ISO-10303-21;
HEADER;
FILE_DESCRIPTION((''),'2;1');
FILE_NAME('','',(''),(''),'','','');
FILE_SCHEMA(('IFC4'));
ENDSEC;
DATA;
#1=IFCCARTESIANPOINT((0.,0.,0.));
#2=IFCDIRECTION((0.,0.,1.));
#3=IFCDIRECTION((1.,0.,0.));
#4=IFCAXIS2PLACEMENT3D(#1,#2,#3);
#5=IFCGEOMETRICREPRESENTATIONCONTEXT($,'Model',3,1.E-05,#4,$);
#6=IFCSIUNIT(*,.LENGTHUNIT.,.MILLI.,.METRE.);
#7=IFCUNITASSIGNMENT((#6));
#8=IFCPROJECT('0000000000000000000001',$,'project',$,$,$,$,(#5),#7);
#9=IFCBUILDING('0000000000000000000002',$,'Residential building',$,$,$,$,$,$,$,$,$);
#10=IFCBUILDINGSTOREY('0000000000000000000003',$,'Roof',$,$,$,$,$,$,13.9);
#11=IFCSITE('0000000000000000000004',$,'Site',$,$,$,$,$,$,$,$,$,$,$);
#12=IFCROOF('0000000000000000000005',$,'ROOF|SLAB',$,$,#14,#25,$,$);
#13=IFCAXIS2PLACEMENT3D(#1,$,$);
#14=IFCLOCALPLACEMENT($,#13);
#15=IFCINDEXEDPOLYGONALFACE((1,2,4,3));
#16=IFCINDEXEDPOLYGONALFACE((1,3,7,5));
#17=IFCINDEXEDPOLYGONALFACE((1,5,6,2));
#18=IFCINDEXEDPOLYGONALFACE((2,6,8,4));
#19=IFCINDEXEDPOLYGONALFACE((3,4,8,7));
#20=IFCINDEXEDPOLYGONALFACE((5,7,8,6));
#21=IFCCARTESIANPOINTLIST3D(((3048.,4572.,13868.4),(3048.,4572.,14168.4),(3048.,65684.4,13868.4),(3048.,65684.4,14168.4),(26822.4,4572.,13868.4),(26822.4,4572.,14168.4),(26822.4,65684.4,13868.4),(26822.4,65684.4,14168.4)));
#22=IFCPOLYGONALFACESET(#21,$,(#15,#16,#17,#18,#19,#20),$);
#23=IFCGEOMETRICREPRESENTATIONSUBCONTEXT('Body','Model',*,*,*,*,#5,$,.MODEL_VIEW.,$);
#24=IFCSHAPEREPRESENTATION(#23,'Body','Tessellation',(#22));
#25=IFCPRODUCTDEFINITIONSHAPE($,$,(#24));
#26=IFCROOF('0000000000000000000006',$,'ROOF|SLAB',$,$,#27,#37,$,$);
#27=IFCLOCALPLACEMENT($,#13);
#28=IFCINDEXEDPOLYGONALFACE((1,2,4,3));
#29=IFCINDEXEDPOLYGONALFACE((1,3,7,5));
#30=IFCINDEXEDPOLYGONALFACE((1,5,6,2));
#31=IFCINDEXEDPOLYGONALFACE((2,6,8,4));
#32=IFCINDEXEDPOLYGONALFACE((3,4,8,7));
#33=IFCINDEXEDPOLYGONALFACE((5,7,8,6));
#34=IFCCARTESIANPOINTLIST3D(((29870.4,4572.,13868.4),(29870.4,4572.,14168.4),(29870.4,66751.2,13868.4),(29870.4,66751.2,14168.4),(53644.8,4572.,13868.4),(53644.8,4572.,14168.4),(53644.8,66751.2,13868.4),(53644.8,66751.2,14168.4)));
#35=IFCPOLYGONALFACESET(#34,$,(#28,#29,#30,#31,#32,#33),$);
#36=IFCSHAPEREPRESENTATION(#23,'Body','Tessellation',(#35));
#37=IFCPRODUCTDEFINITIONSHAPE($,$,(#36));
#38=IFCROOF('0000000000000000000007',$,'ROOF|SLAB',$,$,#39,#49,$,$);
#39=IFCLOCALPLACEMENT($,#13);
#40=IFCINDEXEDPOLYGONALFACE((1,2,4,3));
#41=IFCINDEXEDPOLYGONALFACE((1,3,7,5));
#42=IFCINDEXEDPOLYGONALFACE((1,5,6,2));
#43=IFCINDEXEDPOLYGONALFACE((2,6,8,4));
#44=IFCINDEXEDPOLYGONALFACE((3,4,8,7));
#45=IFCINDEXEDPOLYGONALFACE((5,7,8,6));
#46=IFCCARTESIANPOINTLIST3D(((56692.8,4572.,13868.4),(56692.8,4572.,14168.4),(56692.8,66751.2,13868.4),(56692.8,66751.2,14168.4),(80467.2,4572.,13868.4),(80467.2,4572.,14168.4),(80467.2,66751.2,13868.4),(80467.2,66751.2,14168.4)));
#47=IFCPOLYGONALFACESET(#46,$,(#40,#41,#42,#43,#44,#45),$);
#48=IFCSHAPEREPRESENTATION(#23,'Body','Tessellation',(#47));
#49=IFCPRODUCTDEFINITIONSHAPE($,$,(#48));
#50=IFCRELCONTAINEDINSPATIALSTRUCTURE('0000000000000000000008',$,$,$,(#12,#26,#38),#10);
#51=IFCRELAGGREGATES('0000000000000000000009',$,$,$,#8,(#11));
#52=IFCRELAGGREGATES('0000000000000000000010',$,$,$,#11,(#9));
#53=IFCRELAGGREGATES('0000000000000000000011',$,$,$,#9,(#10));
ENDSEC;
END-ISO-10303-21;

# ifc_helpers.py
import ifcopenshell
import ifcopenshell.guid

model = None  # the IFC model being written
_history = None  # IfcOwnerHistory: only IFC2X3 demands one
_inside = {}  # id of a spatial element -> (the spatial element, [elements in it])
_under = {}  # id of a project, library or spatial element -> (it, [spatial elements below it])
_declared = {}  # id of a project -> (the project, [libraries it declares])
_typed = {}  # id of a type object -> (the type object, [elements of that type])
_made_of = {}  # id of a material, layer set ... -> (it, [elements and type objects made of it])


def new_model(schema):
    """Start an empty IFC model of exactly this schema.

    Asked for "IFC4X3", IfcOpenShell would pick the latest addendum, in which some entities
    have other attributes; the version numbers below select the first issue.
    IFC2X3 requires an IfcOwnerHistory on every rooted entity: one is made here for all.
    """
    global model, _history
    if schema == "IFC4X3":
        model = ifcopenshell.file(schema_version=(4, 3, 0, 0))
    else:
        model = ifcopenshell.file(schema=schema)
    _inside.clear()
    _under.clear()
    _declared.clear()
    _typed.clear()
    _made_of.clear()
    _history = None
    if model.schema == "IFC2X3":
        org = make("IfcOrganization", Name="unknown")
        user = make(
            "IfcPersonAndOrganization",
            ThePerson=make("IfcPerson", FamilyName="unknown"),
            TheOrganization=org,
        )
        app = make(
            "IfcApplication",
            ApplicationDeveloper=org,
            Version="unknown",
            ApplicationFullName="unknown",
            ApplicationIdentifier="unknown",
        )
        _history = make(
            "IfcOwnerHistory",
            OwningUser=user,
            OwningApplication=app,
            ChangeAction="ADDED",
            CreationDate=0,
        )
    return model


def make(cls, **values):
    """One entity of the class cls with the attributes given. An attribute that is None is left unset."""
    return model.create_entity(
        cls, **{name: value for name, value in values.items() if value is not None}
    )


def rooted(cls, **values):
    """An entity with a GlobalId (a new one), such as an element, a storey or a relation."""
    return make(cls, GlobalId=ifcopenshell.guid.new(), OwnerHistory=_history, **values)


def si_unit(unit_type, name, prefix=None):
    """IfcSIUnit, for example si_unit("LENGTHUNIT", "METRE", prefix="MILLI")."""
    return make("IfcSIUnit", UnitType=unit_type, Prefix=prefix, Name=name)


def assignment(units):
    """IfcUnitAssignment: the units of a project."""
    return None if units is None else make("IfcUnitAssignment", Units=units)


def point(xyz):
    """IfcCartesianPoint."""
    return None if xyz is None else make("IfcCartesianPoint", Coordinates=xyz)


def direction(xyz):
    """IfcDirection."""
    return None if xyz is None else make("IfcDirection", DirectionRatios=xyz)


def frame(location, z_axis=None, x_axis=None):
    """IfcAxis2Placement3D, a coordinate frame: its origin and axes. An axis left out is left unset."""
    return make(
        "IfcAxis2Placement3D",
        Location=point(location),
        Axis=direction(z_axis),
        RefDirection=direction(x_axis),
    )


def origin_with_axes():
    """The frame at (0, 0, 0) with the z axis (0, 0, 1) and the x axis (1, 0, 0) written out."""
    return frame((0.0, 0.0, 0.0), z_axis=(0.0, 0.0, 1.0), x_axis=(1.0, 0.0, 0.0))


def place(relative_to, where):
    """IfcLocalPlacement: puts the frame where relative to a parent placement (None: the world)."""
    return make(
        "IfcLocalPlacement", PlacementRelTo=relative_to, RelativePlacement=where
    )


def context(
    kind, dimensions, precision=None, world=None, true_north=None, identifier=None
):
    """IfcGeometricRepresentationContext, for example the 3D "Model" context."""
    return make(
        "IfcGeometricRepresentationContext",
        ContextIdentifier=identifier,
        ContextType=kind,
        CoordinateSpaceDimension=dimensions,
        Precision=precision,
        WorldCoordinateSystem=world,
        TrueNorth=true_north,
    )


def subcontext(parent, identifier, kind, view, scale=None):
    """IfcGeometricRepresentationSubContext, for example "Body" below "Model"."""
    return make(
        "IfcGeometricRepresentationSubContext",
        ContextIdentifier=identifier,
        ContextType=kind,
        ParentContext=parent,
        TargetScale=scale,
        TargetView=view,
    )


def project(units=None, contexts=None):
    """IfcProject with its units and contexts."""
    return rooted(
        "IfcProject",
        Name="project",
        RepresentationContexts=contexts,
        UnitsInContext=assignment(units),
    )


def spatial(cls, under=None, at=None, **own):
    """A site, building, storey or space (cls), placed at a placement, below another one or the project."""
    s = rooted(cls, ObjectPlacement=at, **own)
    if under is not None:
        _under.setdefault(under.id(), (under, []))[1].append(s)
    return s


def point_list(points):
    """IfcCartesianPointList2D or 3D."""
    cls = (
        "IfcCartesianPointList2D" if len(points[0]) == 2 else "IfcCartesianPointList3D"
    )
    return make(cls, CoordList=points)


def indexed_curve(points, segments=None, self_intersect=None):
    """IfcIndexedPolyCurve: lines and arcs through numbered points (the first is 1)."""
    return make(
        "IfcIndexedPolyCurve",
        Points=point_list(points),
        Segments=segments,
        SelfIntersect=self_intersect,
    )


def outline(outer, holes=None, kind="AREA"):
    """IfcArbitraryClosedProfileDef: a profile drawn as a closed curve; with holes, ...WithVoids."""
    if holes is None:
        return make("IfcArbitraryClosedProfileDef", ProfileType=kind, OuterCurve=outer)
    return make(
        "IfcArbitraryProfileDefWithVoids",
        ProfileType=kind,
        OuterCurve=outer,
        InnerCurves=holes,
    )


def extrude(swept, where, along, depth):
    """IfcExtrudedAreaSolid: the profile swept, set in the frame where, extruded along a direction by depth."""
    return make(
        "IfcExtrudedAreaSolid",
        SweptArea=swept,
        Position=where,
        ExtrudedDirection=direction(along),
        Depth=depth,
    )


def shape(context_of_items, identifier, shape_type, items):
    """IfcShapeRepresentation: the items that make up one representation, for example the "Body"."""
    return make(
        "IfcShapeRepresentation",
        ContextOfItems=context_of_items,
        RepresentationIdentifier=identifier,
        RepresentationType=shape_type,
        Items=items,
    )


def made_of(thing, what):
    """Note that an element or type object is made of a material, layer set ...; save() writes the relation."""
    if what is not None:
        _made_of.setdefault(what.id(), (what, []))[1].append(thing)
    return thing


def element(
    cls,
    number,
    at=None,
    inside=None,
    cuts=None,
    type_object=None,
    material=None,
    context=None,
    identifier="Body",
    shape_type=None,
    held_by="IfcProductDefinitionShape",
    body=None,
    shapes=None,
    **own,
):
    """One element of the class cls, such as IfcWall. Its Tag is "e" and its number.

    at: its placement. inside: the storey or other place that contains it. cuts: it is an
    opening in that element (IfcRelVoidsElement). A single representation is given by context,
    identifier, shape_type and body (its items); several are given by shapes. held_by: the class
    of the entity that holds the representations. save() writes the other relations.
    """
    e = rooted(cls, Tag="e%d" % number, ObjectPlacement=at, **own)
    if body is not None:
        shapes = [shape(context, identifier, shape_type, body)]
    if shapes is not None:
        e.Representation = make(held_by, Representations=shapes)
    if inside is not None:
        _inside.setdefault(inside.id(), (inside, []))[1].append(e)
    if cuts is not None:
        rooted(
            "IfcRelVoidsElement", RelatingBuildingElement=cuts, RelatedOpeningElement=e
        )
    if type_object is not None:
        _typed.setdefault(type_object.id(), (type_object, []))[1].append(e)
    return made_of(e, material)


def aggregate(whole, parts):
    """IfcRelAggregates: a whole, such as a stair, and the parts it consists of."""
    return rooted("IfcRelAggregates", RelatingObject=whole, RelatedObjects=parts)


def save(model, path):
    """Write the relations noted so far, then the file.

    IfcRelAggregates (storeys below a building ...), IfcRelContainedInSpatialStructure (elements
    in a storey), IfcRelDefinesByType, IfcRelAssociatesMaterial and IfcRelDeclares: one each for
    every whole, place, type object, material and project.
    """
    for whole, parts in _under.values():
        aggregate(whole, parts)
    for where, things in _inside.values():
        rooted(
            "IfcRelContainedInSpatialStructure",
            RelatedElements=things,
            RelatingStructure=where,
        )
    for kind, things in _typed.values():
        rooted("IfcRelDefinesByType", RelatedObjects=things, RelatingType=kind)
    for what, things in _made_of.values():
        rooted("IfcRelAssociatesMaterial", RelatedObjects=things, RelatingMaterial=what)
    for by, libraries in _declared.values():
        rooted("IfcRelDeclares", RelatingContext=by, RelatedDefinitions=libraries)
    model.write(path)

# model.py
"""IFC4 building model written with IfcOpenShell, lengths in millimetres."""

from ifc_helpers import new_model, si_unit, frame, origin_with_axes, place, context, subcontext, project, spatial, indexed_curve, outline, extrude, element, save


model = new_model("IFC4")

# Units and contexts
model_context = context("Model", 3, precision=1e-05, world=origin_with_axes())
body_context = subcontext(model_context, "Body", "Model", "MODEL_VIEW")
ifc_project = project(units=[si_unit("LENGTHUNIT", "METRE", prefix="MILLI")], contexts=[model_context])

# Site, building, storey
site = spatial("IfcSite", under=ifc_project, Name="Site")
building = spatial("IfcBuilding", under=site, Name="Residential building")
storey = spatial("IfcBuildingStorey", under=building, Name="Roof", Elevation=13.9)

# Roofs
roof_placement = place(None, frame((3048.0, 4572.0, 13868.4), z_axis=(0.0, 0.0, 1.0), x_axis=(1.0, 0.0, 0.0)))
element("IfcRoof", 1, at=roof_placement, inside=storey, Name="ROOF|SLAB", context=body_context, shape_type="SweptSolid", body=[
    extrude(outline(indexed_curve([(0.0, 0.0), (23774.4, 0.0), (23774.4, 61112.4), (0.0, 61112.4), (0.0, 0.0)])), None, (0.0, 0.0, 1.0), 300.0),
])
for number, where, z_axis, x_axis, name in (
    (2, (29870.4, 4572.0, 13868.4), (0.0, 0.0, 1.0), (1.0, 0.0, 0.0), "ROOF|SLAB"),
    (3, (56692.8, 4572.0, 13868.4), (0.0, 0.0, 1.0), (1.0, 0.0, 0.0), "ROOF|SLAB"),
):
    element("IfcRoof", number, at=place(None, frame(where, z_axis=z_axis, x_axis=x_axis)), inside=storey, Name=name, context=body_context, shape_type="SweptSolid", body=[
        extrude(outline(indexed_curve([(0.0, 0.0), (23774.4, 0.0), (23774.4, 62179.2), (0.0, 62179.2), (0.0, 0.0)])), None, (0.0, 0.0, 1.0), 300.0),
    ])

save(model, "model.ifc")
